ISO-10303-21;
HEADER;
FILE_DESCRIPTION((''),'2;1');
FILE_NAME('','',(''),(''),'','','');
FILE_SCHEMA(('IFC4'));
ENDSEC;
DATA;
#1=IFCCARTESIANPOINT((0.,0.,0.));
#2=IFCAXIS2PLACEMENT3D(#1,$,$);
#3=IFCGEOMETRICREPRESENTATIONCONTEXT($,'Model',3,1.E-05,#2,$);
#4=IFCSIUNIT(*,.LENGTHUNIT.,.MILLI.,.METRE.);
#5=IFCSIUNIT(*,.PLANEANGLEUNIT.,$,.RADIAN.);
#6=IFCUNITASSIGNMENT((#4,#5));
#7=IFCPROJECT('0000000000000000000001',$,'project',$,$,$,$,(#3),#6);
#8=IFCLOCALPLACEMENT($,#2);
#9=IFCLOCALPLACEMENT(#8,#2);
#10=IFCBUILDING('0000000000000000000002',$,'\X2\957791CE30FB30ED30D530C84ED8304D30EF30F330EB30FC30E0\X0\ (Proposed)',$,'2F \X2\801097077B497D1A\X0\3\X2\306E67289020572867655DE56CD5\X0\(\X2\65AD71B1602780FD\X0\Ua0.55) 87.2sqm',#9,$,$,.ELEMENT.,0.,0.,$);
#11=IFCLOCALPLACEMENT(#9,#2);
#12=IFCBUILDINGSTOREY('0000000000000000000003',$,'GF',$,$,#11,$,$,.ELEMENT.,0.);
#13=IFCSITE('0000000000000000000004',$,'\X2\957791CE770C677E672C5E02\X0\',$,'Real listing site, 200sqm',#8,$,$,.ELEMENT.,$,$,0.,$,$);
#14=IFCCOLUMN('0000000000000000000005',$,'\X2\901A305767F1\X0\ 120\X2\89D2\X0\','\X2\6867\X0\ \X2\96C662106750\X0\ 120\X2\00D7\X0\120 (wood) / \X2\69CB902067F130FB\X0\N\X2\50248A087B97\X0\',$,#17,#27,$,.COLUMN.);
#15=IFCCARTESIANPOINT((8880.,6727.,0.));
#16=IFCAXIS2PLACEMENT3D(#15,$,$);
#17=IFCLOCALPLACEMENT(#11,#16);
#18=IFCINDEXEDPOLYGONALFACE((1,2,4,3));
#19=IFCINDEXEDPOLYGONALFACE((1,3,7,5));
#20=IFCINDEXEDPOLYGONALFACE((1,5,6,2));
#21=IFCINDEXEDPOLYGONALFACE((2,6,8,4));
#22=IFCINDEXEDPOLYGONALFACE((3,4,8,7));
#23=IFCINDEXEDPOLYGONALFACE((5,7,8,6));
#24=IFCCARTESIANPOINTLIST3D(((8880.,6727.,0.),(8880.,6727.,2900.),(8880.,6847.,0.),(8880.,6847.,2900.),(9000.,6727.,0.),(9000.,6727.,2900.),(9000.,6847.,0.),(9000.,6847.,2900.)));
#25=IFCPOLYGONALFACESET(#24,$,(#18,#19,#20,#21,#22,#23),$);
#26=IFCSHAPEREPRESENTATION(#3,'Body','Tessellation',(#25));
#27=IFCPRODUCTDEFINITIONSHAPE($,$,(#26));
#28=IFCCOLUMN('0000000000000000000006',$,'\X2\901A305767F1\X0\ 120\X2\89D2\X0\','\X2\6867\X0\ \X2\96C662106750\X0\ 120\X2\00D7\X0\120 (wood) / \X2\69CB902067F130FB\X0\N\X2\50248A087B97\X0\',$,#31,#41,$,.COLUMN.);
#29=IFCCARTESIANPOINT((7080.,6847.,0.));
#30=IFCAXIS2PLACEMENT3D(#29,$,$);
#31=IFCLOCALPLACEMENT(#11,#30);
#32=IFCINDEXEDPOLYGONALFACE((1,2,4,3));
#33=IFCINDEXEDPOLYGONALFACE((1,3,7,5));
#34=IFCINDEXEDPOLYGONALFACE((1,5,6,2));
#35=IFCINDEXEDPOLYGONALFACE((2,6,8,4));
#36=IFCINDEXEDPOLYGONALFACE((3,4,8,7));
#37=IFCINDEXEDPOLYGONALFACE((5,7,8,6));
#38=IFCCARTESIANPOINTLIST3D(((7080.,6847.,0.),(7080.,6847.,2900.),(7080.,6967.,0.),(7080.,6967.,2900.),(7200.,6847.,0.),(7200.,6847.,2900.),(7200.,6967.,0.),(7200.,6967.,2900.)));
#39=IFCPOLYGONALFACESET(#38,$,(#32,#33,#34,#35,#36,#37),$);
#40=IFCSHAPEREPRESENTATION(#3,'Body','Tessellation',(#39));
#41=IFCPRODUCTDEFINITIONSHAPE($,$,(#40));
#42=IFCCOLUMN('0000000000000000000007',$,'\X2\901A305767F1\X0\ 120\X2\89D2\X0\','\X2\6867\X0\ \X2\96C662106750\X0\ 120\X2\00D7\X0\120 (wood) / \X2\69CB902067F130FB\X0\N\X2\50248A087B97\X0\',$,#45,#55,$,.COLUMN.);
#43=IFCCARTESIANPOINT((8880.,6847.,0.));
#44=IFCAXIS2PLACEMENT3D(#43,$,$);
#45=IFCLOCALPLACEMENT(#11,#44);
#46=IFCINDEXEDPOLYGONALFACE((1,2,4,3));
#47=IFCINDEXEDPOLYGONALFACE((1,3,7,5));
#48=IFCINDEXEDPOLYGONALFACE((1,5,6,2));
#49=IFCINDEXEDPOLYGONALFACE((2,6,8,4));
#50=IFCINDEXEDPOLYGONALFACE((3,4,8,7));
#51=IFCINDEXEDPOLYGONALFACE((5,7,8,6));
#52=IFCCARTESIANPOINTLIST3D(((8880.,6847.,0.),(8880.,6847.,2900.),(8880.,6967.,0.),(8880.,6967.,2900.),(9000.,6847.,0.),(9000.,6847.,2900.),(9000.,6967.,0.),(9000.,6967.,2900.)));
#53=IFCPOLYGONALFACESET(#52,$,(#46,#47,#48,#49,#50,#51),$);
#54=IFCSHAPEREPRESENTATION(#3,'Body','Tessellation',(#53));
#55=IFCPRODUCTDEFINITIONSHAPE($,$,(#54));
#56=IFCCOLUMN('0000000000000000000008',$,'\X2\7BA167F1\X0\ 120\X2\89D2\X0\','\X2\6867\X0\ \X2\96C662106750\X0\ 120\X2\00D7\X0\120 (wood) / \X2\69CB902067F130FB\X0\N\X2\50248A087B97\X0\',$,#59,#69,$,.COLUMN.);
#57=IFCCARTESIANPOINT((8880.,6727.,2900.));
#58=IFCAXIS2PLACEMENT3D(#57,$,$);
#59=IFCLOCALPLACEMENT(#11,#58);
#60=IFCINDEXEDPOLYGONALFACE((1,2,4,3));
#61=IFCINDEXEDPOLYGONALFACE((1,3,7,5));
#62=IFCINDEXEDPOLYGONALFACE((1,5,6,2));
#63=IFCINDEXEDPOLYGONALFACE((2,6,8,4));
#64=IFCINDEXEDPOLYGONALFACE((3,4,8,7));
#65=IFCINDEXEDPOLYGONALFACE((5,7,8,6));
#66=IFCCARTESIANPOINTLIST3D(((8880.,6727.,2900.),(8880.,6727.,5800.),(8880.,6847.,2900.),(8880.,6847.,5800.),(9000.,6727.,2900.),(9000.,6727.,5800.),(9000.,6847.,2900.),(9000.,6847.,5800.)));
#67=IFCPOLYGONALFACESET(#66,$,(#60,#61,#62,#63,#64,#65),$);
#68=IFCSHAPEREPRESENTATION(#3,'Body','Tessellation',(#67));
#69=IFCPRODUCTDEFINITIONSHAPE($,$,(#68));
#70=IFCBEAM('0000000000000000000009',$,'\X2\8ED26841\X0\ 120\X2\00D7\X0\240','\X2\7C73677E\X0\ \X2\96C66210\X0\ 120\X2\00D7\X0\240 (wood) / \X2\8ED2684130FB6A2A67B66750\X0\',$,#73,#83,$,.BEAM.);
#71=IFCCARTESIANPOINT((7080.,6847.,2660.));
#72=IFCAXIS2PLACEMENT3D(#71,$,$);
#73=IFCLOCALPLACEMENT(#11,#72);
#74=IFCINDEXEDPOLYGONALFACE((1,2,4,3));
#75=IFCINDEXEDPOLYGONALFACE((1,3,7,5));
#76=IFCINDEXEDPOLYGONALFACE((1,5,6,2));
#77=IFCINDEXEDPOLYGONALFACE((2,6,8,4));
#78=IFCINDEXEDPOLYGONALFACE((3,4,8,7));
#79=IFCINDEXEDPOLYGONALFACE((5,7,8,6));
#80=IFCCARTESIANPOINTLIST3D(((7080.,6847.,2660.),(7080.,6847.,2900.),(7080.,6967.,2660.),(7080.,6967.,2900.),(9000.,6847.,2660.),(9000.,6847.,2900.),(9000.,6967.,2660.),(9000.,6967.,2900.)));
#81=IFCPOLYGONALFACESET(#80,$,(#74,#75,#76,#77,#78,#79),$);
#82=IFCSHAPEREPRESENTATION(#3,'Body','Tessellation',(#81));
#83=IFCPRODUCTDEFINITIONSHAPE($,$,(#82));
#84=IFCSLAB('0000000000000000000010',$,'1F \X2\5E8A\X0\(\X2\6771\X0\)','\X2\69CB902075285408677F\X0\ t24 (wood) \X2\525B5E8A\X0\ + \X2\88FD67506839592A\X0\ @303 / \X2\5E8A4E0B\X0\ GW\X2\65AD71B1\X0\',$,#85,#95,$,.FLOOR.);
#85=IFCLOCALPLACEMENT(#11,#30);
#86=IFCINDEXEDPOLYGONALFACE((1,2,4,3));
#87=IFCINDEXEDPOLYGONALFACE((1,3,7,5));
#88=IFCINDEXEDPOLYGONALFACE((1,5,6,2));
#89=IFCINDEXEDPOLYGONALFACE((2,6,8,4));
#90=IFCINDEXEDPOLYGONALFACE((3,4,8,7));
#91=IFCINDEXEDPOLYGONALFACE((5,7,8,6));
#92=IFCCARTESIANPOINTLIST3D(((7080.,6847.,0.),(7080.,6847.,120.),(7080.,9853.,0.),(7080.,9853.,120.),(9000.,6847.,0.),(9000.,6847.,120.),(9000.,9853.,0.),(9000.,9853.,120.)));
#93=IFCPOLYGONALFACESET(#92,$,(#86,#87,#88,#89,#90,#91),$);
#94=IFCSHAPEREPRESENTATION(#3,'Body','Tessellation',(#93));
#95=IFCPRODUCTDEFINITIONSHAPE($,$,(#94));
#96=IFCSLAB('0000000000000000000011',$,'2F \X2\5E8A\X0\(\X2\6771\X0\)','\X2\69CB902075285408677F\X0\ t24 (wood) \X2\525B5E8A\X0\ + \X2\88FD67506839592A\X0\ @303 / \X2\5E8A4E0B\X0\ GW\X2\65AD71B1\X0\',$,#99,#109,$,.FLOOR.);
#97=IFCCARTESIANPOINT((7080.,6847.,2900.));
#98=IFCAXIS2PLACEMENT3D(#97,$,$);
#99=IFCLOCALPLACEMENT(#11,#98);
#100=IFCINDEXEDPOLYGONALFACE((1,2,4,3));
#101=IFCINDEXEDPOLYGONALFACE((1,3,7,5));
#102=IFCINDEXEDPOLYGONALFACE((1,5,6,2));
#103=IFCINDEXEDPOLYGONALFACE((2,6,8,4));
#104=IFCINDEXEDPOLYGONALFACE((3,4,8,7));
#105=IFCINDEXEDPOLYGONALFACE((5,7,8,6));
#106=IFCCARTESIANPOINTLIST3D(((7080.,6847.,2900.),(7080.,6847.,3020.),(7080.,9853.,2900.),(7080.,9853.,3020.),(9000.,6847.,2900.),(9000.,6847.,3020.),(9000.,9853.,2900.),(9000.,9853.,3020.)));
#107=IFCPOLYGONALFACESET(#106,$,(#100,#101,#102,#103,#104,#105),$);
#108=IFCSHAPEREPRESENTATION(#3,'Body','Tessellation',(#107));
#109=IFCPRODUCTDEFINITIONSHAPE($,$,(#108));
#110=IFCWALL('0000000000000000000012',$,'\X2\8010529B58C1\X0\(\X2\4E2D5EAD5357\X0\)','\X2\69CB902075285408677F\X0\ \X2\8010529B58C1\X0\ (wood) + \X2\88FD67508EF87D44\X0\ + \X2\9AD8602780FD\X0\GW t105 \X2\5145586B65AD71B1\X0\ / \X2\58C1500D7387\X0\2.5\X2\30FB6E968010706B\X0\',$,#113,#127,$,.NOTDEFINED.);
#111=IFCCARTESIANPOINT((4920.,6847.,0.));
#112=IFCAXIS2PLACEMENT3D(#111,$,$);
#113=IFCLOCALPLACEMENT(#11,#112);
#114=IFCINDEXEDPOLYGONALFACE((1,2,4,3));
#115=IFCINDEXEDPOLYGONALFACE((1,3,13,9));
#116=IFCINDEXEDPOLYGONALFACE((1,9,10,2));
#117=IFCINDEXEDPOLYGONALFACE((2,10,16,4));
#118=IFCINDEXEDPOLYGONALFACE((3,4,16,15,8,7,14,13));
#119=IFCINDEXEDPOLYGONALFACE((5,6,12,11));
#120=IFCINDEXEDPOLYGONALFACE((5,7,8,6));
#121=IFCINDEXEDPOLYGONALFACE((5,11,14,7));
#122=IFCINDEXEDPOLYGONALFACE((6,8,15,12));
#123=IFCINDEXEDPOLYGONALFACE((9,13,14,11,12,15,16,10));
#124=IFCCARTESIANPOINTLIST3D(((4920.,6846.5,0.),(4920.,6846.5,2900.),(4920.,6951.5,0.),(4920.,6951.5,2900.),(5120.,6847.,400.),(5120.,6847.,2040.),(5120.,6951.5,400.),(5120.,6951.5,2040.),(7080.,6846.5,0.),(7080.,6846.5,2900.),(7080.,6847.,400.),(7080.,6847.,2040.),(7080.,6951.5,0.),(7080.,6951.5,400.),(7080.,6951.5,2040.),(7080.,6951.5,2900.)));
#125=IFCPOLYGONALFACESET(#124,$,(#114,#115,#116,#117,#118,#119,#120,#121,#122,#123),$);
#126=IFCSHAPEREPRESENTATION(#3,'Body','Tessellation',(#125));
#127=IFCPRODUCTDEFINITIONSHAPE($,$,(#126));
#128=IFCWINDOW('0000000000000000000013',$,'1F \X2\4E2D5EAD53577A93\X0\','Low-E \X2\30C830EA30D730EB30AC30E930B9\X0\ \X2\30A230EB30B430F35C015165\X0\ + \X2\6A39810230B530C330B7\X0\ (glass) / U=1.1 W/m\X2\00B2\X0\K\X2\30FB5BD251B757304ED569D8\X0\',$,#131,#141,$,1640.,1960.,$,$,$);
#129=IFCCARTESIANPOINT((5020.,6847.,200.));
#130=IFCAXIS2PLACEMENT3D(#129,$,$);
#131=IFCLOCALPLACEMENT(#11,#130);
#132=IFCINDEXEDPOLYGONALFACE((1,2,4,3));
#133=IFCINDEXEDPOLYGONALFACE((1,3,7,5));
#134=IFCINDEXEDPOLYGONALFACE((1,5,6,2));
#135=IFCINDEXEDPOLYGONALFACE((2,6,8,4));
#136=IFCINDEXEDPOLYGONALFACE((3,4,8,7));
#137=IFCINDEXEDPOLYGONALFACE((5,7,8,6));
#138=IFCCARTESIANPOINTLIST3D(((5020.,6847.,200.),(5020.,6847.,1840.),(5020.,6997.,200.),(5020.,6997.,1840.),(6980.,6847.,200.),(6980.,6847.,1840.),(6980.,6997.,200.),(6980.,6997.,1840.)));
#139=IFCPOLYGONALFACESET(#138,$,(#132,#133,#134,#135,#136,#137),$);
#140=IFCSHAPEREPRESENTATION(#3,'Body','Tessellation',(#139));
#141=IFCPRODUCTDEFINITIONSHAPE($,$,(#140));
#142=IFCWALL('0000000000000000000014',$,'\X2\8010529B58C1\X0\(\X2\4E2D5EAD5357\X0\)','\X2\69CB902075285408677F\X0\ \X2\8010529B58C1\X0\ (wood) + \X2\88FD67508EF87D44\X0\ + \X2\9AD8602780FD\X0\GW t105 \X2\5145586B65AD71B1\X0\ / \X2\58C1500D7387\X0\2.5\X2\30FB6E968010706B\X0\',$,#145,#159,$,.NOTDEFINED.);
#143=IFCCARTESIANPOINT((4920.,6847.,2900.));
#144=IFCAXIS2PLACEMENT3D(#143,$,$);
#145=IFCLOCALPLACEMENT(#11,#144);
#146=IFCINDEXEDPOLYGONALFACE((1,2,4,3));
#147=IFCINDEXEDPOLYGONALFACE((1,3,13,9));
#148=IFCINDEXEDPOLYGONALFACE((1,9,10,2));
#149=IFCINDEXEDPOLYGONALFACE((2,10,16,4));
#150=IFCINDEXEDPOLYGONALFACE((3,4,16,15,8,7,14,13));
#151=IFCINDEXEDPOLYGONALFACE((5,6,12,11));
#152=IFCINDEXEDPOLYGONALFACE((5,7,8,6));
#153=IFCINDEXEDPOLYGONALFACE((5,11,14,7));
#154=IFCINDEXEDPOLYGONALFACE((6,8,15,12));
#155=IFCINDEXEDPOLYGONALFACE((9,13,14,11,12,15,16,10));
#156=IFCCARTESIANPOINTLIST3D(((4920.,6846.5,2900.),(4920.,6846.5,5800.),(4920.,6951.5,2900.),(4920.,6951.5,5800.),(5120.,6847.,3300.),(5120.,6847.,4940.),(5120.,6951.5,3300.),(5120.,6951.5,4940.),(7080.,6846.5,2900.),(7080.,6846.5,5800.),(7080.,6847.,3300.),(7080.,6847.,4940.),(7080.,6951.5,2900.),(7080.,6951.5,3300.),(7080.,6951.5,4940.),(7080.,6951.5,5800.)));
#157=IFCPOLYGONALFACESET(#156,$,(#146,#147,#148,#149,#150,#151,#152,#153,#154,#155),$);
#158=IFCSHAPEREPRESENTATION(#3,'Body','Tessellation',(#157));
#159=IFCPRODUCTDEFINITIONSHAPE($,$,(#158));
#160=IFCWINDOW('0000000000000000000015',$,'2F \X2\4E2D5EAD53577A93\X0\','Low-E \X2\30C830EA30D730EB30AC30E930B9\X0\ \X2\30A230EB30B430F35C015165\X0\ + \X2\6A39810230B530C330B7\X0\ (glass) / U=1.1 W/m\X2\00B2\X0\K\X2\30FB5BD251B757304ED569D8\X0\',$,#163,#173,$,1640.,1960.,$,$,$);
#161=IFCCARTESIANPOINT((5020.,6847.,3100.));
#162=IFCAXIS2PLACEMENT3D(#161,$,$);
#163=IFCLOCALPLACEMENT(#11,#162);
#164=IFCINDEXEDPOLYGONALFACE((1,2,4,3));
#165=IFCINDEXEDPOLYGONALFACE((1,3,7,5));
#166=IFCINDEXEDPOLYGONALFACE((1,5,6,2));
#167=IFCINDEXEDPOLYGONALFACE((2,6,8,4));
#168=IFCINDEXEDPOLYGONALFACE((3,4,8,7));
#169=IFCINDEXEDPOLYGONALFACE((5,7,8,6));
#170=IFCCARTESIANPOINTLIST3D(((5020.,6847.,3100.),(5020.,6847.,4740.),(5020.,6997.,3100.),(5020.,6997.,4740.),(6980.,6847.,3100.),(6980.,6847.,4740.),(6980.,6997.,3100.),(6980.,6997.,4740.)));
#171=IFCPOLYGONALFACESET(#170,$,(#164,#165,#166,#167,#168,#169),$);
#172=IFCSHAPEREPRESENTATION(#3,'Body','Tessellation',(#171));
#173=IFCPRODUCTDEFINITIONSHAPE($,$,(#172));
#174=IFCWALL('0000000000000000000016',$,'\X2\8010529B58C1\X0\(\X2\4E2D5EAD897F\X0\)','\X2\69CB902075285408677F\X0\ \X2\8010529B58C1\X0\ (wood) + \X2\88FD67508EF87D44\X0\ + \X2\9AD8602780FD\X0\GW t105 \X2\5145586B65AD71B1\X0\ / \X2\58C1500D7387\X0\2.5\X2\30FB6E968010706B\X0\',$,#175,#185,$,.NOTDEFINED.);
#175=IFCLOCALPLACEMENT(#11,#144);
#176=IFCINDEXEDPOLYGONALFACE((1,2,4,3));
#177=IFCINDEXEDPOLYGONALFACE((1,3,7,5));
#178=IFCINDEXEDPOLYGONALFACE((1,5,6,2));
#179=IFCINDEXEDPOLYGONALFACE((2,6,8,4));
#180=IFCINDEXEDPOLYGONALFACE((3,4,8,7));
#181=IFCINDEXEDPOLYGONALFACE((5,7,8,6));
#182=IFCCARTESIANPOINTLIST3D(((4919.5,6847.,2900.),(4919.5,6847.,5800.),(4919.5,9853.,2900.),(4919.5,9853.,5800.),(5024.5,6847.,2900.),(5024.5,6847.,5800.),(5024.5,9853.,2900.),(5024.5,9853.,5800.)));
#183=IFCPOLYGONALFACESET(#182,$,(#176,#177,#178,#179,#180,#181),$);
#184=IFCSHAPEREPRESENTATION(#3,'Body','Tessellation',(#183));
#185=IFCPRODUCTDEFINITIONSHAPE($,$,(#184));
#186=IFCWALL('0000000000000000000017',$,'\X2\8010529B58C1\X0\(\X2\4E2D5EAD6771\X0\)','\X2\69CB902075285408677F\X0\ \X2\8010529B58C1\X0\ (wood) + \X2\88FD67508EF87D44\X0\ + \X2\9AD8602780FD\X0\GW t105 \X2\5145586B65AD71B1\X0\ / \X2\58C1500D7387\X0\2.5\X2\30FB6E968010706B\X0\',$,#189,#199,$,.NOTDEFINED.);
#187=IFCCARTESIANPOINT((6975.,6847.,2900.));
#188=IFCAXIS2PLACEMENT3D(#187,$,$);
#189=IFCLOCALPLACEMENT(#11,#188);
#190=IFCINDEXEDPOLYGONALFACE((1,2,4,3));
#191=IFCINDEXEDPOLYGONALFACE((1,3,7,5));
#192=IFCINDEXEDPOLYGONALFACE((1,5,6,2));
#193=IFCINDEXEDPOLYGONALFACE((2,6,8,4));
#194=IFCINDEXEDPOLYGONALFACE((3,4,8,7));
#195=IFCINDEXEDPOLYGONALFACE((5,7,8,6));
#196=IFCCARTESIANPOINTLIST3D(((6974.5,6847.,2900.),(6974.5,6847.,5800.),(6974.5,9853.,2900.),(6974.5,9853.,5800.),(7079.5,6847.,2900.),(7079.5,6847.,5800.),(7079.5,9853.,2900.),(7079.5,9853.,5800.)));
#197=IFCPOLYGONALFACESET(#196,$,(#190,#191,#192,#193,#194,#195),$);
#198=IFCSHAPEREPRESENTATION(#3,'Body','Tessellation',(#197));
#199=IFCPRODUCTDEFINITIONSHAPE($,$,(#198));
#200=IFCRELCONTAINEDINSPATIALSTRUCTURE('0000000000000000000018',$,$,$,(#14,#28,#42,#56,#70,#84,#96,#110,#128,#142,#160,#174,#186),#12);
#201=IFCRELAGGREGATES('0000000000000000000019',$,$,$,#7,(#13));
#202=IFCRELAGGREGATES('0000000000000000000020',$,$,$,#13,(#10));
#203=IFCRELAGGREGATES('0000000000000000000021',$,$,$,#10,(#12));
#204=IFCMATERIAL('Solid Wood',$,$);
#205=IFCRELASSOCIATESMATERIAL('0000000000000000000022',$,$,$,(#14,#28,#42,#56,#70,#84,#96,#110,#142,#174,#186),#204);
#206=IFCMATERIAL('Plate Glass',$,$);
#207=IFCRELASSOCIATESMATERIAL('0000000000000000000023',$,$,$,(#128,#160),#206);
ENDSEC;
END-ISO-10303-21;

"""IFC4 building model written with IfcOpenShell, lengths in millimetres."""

from ifc_helpers import new_model, si_unit, frame, frame_2d, origin, place, context, project, spatial, rectangle, extrude, material, element, fill, save


model = new_model("IFC4")

# Units and contexts
model_context = context("Model", 3, precision=1e-05, world=origin())
ifc_project = project(units=[si_unit("LENGTHUNIT", "METRE", prefix="MILLI"), si_unit("PLANEANGLEUNIT", "RADIAN")], contexts=[model_context])

# Site, building, storey
site_placement = place(None, origin())
site = spatial("IfcSite", under=ifc_project, at=site_placement, Name="長野県松本市", ObjectType="Real listing site, 200sqm", CompositionType="ELEMENT", RefElevation=0.0)
building_placement = place(site_placement, origin())
building = spatial("IfcBuilding", under=site, at=building_placement, Name="長野・ロフト付きワンルーム (Proposed)", ObjectType="2F 耐震等級3の木造在来工法(断熱性能Ua0.55) 87.2sqm", CompositionType="ELEMENT", ElevationOfRefHeight=0.0, ElevationOfTerrain=0.0)
storey_placement = place(building_placement, origin())
storey = spatial("IfcBuildingStorey", under=building, at=storey_placement, Name="GF", CompositionType="ELEMENT", Elevation=0.0)

# Columns
ifc_material_1 = material(Name="Solid Wood")
column_1_placement = place(storey_placement, frame((8880.0, 6727.0, 0.0)))
element("IfcColumn", 1, at=column_1_placement, inside=storey, material=ifc_material_1, Name="通し柱 120角", Description="桧 集成材 120×120 (wood) / 構造柱・N値計算", PredefinedType="COLUMN", context=model_context, shape_type="SweptSolid", body=[
    extrude(rectangle(XDim=120.0, YDim=120.0, at=frame_2d((60.0, 60.0))), frame((8880.0, 6727.0, 0.0)), (0.0, 0.0, 1.0), 2900.0),
])
column_2_placement = place(storey_placement, frame((7080.0, 6847.0, 0.0)))
element("IfcColumn", 2, at=column_2_placement, inside=storey, material=ifc_material_1, Name="通し柱 120角", Description="桧 集成材 120×120 (wood) / 構造柱・N値計算", PredefinedType="COLUMN", context=model_context, shape_type="SweptSolid", body=[
    extrude(rectangle(XDim=120.0, YDim=120.0, at=frame_2d((60.0, 60.0))), frame((7080.0, 6847.0, 0.0)), (0.0, 0.0, 1.0), 2900.0),
])
column_3_placement = place(storey_placement, frame((8880.0, 6847.0, 0.0)))
element("IfcColumn", 3, at=column_3_placement, inside=storey, material=ifc_material_1, Name="通し柱 120角", Description="桧 集成材 120×120 (wood) / 構造柱・N値計算", PredefinedType="COLUMN", context=model_context, shape_type="SweptSolid", body=[
    extrude(rectangle(XDim=120.0, YDim=120.0, at=frame_2d((60.0, 60.0))), frame((8880.0, 6847.0, 0.0)), (0.0, 0.0, 1.0), 2900.0),
])
column_4_placement = place(storey_placement, frame((8880.0, 6727.0, 2900.0)))
element("IfcColumn", 4, at=column_4_placement, inside=storey, material=ifc_material_1, Name="管柱 120角", Description="桧 集成材 120×120 (wood) / 構造柱・N値計算", PredefinedType="COLUMN", context=model_context, shape_type="SweptSolid", body=[
    extrude(rectangle(XDim=120.0, YDim=120.0, at=frame_2d((60.0, 60.0))), frame((8880.0, 6727.0, 2900.0)), (0.0, 0.0, 1.0), 2900.0),
])

# Beam
beam_1_placement = place(storey_placement, frame((7080.0, 6847.0, 2660.0)))
element("IfcBeam", 5, at=beam_1_placement, inside=storey, material=ifc_material_1, Name="軒桁 120×240", Description="米松 集成 120×240 (wood) / 軒桁・横架材", PredefinedType="BEAM", context=model_context, shape_type="SweptSolid", body=[
    extrude(rectangle(XDim=1920.0, YDim=120.0, at=frame_2d((960.0, 60.0))), frame((7080.0, 6847.0, 2660.0)), (0.0, 0.0, 1.0), 240.0),
])

# Slabs
slab_1_placement = place(storey_placement, frame((7080.0, 6847.0, 0.0)))
element("IfcSlab", 6, at=slab_1_placement, inside=storey, material=ifc_material_1, Name="1F 床(東)", Description="構造用合板 t24 (wood) 剛床 + 製材根太 @303 / 床下 GW断熱", PredefinedType="FLOOR", context=model_context, shape_type="SweptSolid", body=[
    extrude(rectangle(XDim=1920.0, YDim=3006.0, at=frame_2d((960.0, 1503.0))), frame((7080.0, 6847.0, 0.0)), (0.0, 0.0, 1.0), 120.0),
])
slab_2_placement = place(storey_placement, frame((7080.0, 6847.0, 2900.0)))
element("IfcSlab", 7, at=slab_2_placement, inside=storey, material=ifc_material_1, Name="2F 床(東)", Description="構造用合板 t24 (wood) 剛床 + 製材根太 @303 / 床下 GW断熱", PredefinedType="FLOOR", context=model_context, shape_type="SweptSolid", body=[
    extrude(rectangle(XDim=1920.0, YDim=3006.0, at=frame_2d((960.0, 1503.0))), frame((7080.0, 6847.0, 2900.0)), (0.0, 0.0, 1.0), 120.0),
])

# Wall, opening, window
wall_1_placement = place(storey_placement, frame((4920.0, 6847.0, 0.0)))
wall_1 = element("IfcWall", 8, at=wall_1_placement, inside=storey, material=ifc_material_1, Name="耐力壁(中庭南)", Description="構造用合板 耐力壁 (wood) + 製材軸組 + 高性能GW t105 充填断熱 / 壁倍率2.5・準耐火", PredefinedType="NOTDEFINED", context=model_context, shape_type="SweptSolid", body=[
    extrude(rectangle(XDim=2160.0, YDim=105.0, at=frame_2d((1080.0, 52.0))), frame((4920.0, 6847.0, 0.0)), (0.0, 0.0, 1.0), 2900.0),
])
opening_1_placement = place(storey_placement, frame((5020.0, 6847.0, 200.0)))
opening_1 = element("IfcOpeningElement", 9, at=opening_1_placement, cuts=wall_1, PredefinedType="NOTDEFINED", context=model_context, shape_type="SweptSolid", body=[
    extrude(rectangle(XDim=1960.0, YDim=150.0, at=frame_2d((980.0, 75.0))), frame((5020.0, 6847.0, 200.0)), (0.0, 0.0, 1.0), 1640.0),
])
ifc_material_2 = material(Name="Plate Glass")
window_1_placement = place(storey_placement, frame((5020.0, 6847.0, 200.0)))
window_1 = element("IfcWindow", 10, at=window_1_placement, inside=storey, material=ifc_material_2, Name="1F 中庭南窓", Description="Low-E トリプルガラス アルゴン封入 + 樹脂サッシ (glass) / U=1.1 W/m²K・寒冷地仕様", OverallHeight=1640.0, OverallWidth=1960.0, context=model_context, shape_type="SweptSolid", body=[
    extrude(rectangle(XDim=1960.0, YDim=150.0, at=frame_2d((980.0, 75.0))), frame((5020.0, 6847.0, 200.0)), (0.0, 0.0, 1.0), 1640.0),
])
fill(opening_1, window_1)

# Wall, opening, window
wall_2_placement = place(storey_placement, frame((4920.0, 6847.0, 2900.0)))
wall_2 = element("IfcWall", 11, at=wall_2_placement, inside=storey, material=ifc_material_1, Name="耐力壁(中庭南)", Description="構造用合板 耐力壁 (wood) + 製材軸組 + 高性能GW t105 充填断熱 / 壁倍率2.5・準耐火", PredefinedType="NOTDEFINED", context=model_context, shape_type="SweptSolid", body=[
    extrude(rectangle(XDim=2160.0, YDim=105.0, at=frame_2d((1080.0, 52.0))), frame((4920.0, 6847.0, 2900.0)), (0.0, 0.0, 1.0), 2900.0),
])
opening_2_placement = place(storey_placement, frame((5020.0, 6847.0, 3100.0)))
opening_2 = element("IfcOpeningElement", 12, at=opening_2_placement, cuts=wall_2, PredefinedType="NOTDEFINED", context=model_context, shape_type="SweptSolid", body=[
    extrude(rectangle(XDim=1960.0, YDim=150.0, at=frame_2d((980.0, 75.0))), frame((5020.0, 6847.0, 3100.0)), (0.0, 0.0, 1.0), 1640.0),
])
window_2_placement = place(storey_placement, frame((5020.0, 6847.0, 3100.0)))
window_2 = element("IfcWindow", 13, at=window_2_placement, inside=storey, material=ifc_material_2, Name="2F 中庭南窓", Description="Low-E トリプルガラス アルゴン封入 + 樹脂サッシ (glass) / U=1.1 W/m²K・寒冷地仕様", OverallHeight=1640.0, OverallWidth=1960.0, context=model_context, shape_type="SweptSolid", body=[
    extrude(rectangle(XDim=1960.0, YDim=150.0, at=frame_2d((980.0, 75.0))), frame((5020.0, 6847.0, 3100.0)), (0.0, 0.0, 1.0), 1640.0),
])
fill(opening_2, window_2)

# Walls
wall_3_placement = place(storey_placement, frame((4920.0, 6847.0, 2900.0)))
element("IfcWall", 14, at=wall_3_placement, inside=storey, material=ifc_material_1, Name="耐力壁(中庭西)", Description="構造用合板 耐力壁 (wood) + 製材軸組 + 高性能GW t105 充填断熱 / 壁倍率2.5・準耐火", PredefinedType="NOTDEFINED", context=model_context, shape_type="SweptSolid", body=[
    extrude(rectangle(XDim=105.0, YDim=3006.0, at=frame_2d((52.0, 1503.0))), frame((4920.0, 6847.0, 2900.0)), (0.0, 0.0, 1.0), 2900.0),
])
wall_4_placement = place(storey_placement, frame((6975.0, 6847.0, 2900.0)))
element("IfcWall", 15, at=wall_4_placement, inside=storey, material=ifc_material_1, Name="耐力壁(中庭東)", Description="構造用合板 耐力壁 (wood) + 製材軸組 + 高性能GW t105 充填断熱 / 壁倍率2.5・準耐火", PredefinedType="NOTDEFINED", context=model_context, shape_type="SweptSolid", body=[
    extrude(rectangle(XDim=105.0, YDim=3006.0, at=frame_2d((52.0, 1503.0))), frame((6975.0, 6847.0, 2900.0)), (0.0, 0.0, 1.0), 2900.0),
])

save(model, "model.ifc")
